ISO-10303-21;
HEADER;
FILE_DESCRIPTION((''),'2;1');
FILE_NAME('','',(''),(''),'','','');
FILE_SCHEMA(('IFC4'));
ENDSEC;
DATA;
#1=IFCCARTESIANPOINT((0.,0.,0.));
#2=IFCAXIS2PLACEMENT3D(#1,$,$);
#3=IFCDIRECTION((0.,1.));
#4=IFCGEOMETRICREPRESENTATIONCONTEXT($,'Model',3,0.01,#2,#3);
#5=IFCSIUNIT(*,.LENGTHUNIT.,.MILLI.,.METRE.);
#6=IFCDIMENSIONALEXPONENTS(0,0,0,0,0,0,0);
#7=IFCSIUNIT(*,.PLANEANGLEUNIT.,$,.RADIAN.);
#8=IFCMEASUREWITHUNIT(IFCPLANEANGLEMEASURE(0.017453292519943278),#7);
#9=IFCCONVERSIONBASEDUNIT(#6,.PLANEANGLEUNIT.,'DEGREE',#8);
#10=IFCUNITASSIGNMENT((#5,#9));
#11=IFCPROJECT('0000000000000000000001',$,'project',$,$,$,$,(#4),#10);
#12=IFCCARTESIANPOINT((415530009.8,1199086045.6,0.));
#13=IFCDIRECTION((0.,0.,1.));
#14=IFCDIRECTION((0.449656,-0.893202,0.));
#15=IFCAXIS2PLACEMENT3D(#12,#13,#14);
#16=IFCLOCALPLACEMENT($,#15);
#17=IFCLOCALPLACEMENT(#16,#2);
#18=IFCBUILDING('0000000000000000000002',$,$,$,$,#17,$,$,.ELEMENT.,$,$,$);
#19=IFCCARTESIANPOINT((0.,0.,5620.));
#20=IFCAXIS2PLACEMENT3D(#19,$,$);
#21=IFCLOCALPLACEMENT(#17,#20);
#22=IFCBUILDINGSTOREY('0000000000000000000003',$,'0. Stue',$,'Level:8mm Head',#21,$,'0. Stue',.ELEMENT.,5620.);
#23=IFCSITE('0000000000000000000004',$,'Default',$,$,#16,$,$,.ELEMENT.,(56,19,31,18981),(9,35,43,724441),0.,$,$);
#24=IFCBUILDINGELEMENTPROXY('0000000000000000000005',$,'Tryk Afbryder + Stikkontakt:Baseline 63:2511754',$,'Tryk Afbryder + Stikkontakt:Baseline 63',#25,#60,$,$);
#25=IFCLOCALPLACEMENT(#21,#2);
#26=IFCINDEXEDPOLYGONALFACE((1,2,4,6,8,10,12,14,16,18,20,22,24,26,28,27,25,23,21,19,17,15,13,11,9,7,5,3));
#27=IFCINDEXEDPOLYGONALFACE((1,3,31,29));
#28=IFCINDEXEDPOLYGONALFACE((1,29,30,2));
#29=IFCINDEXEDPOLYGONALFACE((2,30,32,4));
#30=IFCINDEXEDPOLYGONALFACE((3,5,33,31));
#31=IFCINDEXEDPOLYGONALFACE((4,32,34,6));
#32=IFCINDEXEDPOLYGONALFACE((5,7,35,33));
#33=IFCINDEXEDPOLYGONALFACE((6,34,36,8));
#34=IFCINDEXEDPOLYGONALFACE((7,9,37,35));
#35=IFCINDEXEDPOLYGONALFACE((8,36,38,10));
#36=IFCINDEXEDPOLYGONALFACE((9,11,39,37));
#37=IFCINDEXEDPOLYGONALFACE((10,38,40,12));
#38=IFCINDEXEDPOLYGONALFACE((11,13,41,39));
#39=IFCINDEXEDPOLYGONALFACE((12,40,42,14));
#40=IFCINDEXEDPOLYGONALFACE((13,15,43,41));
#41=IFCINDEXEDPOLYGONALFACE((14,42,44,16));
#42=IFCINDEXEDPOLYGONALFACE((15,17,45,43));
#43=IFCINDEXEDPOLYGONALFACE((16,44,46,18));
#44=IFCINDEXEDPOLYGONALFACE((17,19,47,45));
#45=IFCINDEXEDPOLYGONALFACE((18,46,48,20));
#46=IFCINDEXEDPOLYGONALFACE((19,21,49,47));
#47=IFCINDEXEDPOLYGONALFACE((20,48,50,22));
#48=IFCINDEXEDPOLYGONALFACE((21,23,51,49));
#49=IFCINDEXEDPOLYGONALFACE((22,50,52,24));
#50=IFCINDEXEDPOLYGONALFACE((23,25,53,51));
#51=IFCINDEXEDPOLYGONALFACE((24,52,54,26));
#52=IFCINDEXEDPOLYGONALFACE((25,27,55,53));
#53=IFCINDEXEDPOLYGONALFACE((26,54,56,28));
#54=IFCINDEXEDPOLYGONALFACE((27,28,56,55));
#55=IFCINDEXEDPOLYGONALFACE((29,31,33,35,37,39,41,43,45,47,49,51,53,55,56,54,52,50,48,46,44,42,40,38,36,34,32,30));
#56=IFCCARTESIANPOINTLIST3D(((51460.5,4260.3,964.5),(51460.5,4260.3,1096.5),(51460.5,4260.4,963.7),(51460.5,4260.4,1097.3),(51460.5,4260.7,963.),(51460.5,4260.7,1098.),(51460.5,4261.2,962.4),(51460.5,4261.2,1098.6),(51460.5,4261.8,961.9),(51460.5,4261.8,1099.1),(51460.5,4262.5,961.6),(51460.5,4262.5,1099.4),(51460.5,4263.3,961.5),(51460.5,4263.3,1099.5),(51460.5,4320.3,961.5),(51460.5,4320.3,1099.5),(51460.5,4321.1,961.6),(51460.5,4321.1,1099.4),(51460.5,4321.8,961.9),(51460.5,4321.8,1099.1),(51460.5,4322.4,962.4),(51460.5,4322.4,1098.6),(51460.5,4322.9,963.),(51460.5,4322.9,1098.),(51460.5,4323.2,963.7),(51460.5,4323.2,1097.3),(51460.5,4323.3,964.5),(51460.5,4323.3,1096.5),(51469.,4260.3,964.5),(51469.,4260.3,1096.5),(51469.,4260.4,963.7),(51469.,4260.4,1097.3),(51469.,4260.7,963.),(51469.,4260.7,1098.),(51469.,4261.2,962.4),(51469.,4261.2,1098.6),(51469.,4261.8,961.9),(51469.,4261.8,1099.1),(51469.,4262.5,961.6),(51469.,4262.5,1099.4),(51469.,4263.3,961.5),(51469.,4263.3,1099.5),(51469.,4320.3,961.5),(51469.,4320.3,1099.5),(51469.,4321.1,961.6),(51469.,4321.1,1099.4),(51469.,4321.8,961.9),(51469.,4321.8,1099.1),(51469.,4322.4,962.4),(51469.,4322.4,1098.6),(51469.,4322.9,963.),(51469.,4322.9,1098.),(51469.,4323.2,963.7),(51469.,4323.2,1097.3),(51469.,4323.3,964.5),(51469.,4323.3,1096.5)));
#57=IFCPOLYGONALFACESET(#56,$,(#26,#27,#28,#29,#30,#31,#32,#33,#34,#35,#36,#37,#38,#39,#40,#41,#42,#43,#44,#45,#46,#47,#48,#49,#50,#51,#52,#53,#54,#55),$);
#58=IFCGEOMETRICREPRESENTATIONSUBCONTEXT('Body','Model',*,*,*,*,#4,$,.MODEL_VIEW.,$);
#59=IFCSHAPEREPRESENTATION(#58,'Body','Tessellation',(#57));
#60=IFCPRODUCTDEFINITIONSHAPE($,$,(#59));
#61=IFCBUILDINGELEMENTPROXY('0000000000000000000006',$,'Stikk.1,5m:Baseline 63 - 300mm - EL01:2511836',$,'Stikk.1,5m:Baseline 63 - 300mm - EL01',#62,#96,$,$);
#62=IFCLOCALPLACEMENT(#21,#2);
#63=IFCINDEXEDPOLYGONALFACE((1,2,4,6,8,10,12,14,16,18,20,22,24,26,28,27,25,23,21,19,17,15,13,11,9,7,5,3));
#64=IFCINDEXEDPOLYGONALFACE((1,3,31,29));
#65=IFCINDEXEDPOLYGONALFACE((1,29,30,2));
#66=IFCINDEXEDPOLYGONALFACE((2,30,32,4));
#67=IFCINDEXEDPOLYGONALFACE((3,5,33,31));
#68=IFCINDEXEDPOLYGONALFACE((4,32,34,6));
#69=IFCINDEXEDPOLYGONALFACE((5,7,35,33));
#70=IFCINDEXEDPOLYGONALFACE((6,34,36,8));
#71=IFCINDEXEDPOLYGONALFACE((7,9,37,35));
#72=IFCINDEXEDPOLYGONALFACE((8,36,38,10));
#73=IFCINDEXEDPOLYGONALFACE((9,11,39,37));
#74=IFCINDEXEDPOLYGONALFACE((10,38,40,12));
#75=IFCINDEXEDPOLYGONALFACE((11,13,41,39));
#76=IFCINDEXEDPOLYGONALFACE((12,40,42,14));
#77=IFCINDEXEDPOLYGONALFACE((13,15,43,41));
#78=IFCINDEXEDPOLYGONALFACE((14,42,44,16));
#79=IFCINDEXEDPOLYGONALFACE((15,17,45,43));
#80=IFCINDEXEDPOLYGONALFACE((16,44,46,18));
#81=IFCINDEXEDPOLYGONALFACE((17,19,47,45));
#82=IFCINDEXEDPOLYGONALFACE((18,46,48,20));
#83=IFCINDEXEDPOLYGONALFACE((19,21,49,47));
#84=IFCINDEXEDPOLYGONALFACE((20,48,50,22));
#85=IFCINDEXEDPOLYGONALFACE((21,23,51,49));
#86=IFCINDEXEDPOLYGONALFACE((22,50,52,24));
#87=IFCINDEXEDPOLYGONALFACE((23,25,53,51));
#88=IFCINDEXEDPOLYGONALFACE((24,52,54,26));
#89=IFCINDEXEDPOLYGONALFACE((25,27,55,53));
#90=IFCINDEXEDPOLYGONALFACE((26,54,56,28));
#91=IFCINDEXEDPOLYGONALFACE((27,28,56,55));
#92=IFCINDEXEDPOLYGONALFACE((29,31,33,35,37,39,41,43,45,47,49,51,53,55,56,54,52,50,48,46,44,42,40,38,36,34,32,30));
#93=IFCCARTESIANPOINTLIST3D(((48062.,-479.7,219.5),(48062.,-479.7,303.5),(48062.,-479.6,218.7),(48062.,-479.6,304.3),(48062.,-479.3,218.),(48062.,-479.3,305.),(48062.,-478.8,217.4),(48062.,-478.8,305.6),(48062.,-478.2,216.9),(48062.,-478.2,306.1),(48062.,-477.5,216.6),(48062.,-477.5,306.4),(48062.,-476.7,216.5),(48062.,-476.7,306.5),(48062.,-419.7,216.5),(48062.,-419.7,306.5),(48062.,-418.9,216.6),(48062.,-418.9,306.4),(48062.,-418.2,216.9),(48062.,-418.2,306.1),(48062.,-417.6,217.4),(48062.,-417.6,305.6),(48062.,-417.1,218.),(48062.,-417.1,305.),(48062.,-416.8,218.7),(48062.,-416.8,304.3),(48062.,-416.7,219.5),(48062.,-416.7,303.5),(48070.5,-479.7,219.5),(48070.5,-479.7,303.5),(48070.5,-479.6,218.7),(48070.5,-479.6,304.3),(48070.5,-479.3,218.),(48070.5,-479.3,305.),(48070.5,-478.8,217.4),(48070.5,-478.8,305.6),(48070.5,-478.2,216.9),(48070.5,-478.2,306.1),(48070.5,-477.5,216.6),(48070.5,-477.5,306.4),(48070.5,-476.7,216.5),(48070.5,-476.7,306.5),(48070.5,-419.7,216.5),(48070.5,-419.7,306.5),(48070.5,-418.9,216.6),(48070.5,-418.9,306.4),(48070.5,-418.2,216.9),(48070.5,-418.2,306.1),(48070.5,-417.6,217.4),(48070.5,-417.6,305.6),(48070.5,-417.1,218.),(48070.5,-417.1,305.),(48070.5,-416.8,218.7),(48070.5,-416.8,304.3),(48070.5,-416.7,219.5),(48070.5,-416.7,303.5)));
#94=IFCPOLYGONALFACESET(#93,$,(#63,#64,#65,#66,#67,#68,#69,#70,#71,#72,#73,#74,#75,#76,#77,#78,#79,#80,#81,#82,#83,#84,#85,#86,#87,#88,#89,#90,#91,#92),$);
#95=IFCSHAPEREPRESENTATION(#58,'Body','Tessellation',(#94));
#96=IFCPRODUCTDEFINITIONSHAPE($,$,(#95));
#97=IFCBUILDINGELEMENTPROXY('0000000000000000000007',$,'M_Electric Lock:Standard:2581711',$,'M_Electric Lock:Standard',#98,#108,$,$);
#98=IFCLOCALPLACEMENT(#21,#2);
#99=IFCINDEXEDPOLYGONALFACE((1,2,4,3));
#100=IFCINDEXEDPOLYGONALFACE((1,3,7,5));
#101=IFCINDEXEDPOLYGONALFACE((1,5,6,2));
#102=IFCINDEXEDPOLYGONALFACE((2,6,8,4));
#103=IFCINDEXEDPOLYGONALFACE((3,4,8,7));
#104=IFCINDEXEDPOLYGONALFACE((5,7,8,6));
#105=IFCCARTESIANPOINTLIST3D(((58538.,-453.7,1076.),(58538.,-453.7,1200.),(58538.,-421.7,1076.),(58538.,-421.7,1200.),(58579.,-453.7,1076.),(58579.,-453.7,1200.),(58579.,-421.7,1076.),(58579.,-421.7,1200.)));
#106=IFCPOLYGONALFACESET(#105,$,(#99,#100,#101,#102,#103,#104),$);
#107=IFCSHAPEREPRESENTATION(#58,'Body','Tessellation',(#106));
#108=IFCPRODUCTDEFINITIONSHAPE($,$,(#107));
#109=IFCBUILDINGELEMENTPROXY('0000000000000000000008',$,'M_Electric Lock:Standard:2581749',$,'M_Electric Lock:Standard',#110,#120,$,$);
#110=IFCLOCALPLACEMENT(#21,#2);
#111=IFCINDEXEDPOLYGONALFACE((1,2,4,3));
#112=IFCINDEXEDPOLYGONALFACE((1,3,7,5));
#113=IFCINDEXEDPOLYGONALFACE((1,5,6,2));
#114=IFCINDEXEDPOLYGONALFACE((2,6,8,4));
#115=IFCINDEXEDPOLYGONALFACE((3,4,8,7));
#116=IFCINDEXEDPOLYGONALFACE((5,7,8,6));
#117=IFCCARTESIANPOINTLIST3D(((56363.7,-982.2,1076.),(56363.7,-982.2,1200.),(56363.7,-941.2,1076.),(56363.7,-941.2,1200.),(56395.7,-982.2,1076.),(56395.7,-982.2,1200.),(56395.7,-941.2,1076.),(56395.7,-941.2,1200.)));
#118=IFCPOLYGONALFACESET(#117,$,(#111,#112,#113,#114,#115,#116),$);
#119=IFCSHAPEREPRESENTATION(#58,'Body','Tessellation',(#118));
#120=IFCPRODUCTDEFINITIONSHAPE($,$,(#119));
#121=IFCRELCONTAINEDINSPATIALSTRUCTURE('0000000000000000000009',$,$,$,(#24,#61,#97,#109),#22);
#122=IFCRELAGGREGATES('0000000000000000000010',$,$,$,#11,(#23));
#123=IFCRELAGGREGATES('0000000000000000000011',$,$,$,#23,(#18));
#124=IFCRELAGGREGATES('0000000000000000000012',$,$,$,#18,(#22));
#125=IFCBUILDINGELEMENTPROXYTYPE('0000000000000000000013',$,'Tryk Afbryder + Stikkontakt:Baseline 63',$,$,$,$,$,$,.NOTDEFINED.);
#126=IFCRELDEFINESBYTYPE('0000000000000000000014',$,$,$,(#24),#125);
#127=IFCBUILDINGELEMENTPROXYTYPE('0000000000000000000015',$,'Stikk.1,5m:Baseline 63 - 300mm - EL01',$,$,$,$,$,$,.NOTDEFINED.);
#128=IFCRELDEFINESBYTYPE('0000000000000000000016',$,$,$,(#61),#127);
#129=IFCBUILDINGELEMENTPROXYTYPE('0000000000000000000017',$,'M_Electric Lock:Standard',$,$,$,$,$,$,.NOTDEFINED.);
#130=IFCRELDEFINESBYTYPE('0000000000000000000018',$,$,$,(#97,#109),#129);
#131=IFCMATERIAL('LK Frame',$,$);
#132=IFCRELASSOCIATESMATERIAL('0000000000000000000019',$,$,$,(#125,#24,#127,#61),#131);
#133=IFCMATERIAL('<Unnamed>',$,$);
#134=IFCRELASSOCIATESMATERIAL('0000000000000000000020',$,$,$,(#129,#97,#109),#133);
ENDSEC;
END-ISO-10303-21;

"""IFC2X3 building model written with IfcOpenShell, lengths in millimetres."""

from ifc_helpers import new_model, entity, si_unit, converted_unit, direction, frame, frame_2d, origin, origin_2d_with_axis, place, context, subcontext, project, spatial, polyline, circle_curve, parameter, trimmed, segment, composite_curve, rectangle, outline, extrude, source, transform, mapped, material, type_object, type_shapes, element, save


model = new_model("IFC2X3")

# Units and contexts
model_context = context("Model", 3, precision=0.01, world=origin(), true_north=direction((0.0, 1.0)))
body_context = subcontext(model_context, "Body", "Model", "MODEL_VIEW")
ifc_project = project(units=[si_unit("LENGTHUNIT", "METRE", prefix="MILLI"), converted_unit("PLANEANGLEUNIT", "DEGREE", entity("IfcPlaneAngleMeasure", 0.017453292519943278), si_unit("PLANEANGLEUNIT", "RADIAN"), dimensions=[0, 0, 0, 0, 0, 0, 0])], contexts=[model_context])

# Site, building, storey
site_placement = place(None, frame((415530009.8, 1199086045.6, 0.0), z_axis=(0.0, 0.0, 1.0), x_axis=(0.449656, -0.893202, 0.0)))
site = spatial("IfcSite", under=ifc_project, at=site_placement, Name="Default", CompositionType="ELEMENT", RefLatitude=(56, 19, 31, 18981), RefLongitude=(9, 35, 43, 724441), RefElevation=0.0)
building_placement = place(site_placement, origin())
building = spatial("IfcBuilding", under=site, at=building_placement, CompositionType="ELEMENT")
storey_placement = place(building_placement, frame((0.0, 0.0, 5620.0)))
storey = spatial("IfcBuildingStorey", under=building, at=storey_placement, Name="0. Stue", ObjectType="Level:8mm Head", LongName="0. Stue", CompositionType="ELEMENT", Elevation=5620.0)

# Building element proxies
ifc_material_1 = material(Name="LK Frame")
building_element_proxy_type_1 = type_object("IfcBuildingElementProxyType", Name="Tryk Afbryder + Stikkontakt:Baseline 63", PredefinedType="NOTDEFINED", material=ifc_material_1)
shared_shape_1 = source(origin(), body_context, "Body", "SweptSolid", [
    extrude(outline(composite_curve([segment(polyline([(-66.0, -31.5), (66.0, -31.5)]), True, "CONTINUOUS"), segment(trimmed(circle_curve(frame_2d((66.0, -28.5), x_axis=(-1.0, 0.0)), 3.0), [parameter(90.0)], [parameter(180.0)], True, "PARAMETER"), True, "CONTINUOUS"), segment(polyline([(69.0, -28.5), (69.0, 28.5)]), True, "CONTINUOUS"), segment(trimmed(circle_curve(frame_2d((66.0, 28.5), x_axis=(-1.0, 0.0)), 3.0), [parameter(180.0)], [parameter(270.0)], True, "PARAMETER"), True, "CONTINUOUS"), segment(polyline([(66.0, 31.5), (-66.0, 31.5)]), True, "CONTINUOUS"), segment(trimmed(circle_curve(frame_2d((-66.0, 28.5), x_axis=(1.0, 0.0)), 3.0), [parameter(90.0)], [parameter(180.0)], True, "PARAMETER"), True, "CONTINUOUS"), segment(polyline([(-69.0, 28.5), (-69.0, -28.5)]), True, "CONTINUOUS"), segment(trimmed(circle_curve(frame_2d((-66.0, -28.5), x_axis=(1.0, 0.0)), 3.0), [parameter(180.0)], [parameter(270.0)], True, "PARAMETER"), True, "CONTINUOUS")], self_intersect=False)), frame((0.0, -69.5, 0.0), z_axis=(0.0, 0.0, 1.0), x_axis=(0.0, 1.0, 0.0)), (0.0, 0.0, 1.0), 8.5),
])
type_shapes(building_element_proxy_type_1, [shared_shape_1])
proxy_1_placement = place(storey_placement, frame((51460.5, 4291.8, 1100.0), z_axis=(1.0, 0.0, 0.0), x_axis=(0.0, 1.0, 0.0)))
element("IfcBuildingElementProxy", 1, at=proxy_1_placement, inside=storey, type_object=building_element_proxy_type_1, material=ifc_material_1, Name="Tryk Afbryder + Stikkontakt:Baseline 63:2511754", ObjectType="Tryk Afbryder + Stikkontakt:Baseline 63", context=body_context, shape_type="MappedRepresentation", body=[
    mapped(shared_shape_1, transform((0.0, 0.0, 0.0), scale=1.0)),
])
building_element_proxy_type_2 = type_object("IfcBuildingElementProxyType", Name="Stikk.1,5m:Baseline 63 - 300mm - EL01", PredefinedType="NOTDEFINED", material=ifc_material_1)
shared_shape_2 = source(origin(), body_context, "Body", "SweptSolid", [
    extrude(outline(composite_curve([segment(trimmed(circle_curve(frame_2d((-42.0, 28.5), x_axis=(1.0, 0.0)), 3.0), [parameter(90.0)], [parameter(180.0)], True, "PARAMETER"), True, "CONTINUOUS"), segment(polyline([(-45.0, 28.5), (-45.0, -28.5)]), True, "CONTINUOUS"), segment(trimmed(circle_curve(frame_2d((-42.0, -28.5), x_axis=(1.0, 0.0)), 3.0), [parameter(180.0)], [parameter(270.0)], True, "PARAMETER"), True, "CONTINUOUS"), segment(polyline([(-42.0, -31.5), (42.0, -31.5)]), True, "CONTINUOUS"), segment(trimmed(circle_curve(frame_2d((42.0, -28.5), x_axis=(-1.0, 0.0)), 3.0), [parameter(90.0)], [parameter(180.0)], True, "PARAMETER"), True, "CONTINUOUS"), segment(polyline([(45.0, -28.5), (45.0, 28.5)]), True, "CONTINUOUS"), segment(trimmed(circle_curve(frame_2d((42.0, 28.5), x_axis=(-1.0, 0.0)), 3.0), [parameter(180.0)], [parameter(270.0)], True, "PARAMETER"), True, "CONTINUOUS"), segment(polyline([(42.0, 31.5), (-42.0, 31.5)]), True, "CONTINUOUS")], self_intersect=False)), frame((0.0, 38.5, 0.0), z_axis=(0.0, 0.0, 1.0), x_axis=(0.0, -1.0, 0.0)), (0.0, 0.0, 1.0), 8.5),
])
type_shapes(building_element_proxy_type_2, [shared_shape_2])
proxy_2_placement = place(storey_placement, frame((48070.5, -448.2, 300.0), z_axis=(-1.0, 0.0, 0.0), x_axis=(0.0, 1.0, 0.0)))
element("IfcBuildingElementProxy", 2, at=proxy_2_placement, inside=storey, type_object=building_element_proxy_type_2, material=ifc_material_1, Name="Stikk.1,5m:Baseline 63 - 300mm - EL01:2511836", ObjectType="Stikk.1,5m:Baseline 63 - 300mm - EL01", context=body_context, shape_type="MappedRepresentation", body=[
    mapped(shared_shape_2, transform((0.0, 0.0, 0.0), scale=1.0)),
])
ifc_material_2 = material(Name="<Unnamed>")
building_element_proxy_type_3 = type_object("IfcBuildingElementProxyType", Name="M_Electric Lock:Standard", PredefinedType="NOTDEFINED", material=ifc_material_2)
shared_shape_3 = source(origin(), body_context, "Body", "SweptSolid", [
    extrude(rectangle(XDim=32.0, YDim=124.0, at=origin_2d_with_axis()), frame((0.0, -62.0, 0.0), z_axis=(0.0, 0.0, 1.0), x_axis=(-1.0, 0.0, 0.0)), (0.0, 0.0, 1.0), 41.0),
])
type_shapes(building_element_proxy_type_3, [shared_shape_3])
for number, where, z_axis, x_axis, name in (
    (3, (58538.0, -437.7, 1200.0), (1.0, 0.0, 0.0), (0.0, 1.0, 0.0), "M_Electric Lock:Standard:2581711"),
    (4, (56379.7, -941.2, 1200.0), (0.0, -1.0, 0.0), (1.0, 0.0, 0.0), "M_Electric Lock:Standard:2581749"),
):
    element("IfcBuildingElementProxy", number, at=place(storey_placement, frame(where, z_axis=z_axis, x_axis=x_axis)), inside=storey, type_object=building_element_proxy_type_3, material=ifc_material_2, Name=name, ObjectType="M_Electric Lock:Standard", context=body_context, shape_type="MappedRepresentation", body=[
        mapped(shared_shape_3, transform((0.0, 0.0, 0.0), scale=1.0)),
    ])

save(model, "model.ifc")
